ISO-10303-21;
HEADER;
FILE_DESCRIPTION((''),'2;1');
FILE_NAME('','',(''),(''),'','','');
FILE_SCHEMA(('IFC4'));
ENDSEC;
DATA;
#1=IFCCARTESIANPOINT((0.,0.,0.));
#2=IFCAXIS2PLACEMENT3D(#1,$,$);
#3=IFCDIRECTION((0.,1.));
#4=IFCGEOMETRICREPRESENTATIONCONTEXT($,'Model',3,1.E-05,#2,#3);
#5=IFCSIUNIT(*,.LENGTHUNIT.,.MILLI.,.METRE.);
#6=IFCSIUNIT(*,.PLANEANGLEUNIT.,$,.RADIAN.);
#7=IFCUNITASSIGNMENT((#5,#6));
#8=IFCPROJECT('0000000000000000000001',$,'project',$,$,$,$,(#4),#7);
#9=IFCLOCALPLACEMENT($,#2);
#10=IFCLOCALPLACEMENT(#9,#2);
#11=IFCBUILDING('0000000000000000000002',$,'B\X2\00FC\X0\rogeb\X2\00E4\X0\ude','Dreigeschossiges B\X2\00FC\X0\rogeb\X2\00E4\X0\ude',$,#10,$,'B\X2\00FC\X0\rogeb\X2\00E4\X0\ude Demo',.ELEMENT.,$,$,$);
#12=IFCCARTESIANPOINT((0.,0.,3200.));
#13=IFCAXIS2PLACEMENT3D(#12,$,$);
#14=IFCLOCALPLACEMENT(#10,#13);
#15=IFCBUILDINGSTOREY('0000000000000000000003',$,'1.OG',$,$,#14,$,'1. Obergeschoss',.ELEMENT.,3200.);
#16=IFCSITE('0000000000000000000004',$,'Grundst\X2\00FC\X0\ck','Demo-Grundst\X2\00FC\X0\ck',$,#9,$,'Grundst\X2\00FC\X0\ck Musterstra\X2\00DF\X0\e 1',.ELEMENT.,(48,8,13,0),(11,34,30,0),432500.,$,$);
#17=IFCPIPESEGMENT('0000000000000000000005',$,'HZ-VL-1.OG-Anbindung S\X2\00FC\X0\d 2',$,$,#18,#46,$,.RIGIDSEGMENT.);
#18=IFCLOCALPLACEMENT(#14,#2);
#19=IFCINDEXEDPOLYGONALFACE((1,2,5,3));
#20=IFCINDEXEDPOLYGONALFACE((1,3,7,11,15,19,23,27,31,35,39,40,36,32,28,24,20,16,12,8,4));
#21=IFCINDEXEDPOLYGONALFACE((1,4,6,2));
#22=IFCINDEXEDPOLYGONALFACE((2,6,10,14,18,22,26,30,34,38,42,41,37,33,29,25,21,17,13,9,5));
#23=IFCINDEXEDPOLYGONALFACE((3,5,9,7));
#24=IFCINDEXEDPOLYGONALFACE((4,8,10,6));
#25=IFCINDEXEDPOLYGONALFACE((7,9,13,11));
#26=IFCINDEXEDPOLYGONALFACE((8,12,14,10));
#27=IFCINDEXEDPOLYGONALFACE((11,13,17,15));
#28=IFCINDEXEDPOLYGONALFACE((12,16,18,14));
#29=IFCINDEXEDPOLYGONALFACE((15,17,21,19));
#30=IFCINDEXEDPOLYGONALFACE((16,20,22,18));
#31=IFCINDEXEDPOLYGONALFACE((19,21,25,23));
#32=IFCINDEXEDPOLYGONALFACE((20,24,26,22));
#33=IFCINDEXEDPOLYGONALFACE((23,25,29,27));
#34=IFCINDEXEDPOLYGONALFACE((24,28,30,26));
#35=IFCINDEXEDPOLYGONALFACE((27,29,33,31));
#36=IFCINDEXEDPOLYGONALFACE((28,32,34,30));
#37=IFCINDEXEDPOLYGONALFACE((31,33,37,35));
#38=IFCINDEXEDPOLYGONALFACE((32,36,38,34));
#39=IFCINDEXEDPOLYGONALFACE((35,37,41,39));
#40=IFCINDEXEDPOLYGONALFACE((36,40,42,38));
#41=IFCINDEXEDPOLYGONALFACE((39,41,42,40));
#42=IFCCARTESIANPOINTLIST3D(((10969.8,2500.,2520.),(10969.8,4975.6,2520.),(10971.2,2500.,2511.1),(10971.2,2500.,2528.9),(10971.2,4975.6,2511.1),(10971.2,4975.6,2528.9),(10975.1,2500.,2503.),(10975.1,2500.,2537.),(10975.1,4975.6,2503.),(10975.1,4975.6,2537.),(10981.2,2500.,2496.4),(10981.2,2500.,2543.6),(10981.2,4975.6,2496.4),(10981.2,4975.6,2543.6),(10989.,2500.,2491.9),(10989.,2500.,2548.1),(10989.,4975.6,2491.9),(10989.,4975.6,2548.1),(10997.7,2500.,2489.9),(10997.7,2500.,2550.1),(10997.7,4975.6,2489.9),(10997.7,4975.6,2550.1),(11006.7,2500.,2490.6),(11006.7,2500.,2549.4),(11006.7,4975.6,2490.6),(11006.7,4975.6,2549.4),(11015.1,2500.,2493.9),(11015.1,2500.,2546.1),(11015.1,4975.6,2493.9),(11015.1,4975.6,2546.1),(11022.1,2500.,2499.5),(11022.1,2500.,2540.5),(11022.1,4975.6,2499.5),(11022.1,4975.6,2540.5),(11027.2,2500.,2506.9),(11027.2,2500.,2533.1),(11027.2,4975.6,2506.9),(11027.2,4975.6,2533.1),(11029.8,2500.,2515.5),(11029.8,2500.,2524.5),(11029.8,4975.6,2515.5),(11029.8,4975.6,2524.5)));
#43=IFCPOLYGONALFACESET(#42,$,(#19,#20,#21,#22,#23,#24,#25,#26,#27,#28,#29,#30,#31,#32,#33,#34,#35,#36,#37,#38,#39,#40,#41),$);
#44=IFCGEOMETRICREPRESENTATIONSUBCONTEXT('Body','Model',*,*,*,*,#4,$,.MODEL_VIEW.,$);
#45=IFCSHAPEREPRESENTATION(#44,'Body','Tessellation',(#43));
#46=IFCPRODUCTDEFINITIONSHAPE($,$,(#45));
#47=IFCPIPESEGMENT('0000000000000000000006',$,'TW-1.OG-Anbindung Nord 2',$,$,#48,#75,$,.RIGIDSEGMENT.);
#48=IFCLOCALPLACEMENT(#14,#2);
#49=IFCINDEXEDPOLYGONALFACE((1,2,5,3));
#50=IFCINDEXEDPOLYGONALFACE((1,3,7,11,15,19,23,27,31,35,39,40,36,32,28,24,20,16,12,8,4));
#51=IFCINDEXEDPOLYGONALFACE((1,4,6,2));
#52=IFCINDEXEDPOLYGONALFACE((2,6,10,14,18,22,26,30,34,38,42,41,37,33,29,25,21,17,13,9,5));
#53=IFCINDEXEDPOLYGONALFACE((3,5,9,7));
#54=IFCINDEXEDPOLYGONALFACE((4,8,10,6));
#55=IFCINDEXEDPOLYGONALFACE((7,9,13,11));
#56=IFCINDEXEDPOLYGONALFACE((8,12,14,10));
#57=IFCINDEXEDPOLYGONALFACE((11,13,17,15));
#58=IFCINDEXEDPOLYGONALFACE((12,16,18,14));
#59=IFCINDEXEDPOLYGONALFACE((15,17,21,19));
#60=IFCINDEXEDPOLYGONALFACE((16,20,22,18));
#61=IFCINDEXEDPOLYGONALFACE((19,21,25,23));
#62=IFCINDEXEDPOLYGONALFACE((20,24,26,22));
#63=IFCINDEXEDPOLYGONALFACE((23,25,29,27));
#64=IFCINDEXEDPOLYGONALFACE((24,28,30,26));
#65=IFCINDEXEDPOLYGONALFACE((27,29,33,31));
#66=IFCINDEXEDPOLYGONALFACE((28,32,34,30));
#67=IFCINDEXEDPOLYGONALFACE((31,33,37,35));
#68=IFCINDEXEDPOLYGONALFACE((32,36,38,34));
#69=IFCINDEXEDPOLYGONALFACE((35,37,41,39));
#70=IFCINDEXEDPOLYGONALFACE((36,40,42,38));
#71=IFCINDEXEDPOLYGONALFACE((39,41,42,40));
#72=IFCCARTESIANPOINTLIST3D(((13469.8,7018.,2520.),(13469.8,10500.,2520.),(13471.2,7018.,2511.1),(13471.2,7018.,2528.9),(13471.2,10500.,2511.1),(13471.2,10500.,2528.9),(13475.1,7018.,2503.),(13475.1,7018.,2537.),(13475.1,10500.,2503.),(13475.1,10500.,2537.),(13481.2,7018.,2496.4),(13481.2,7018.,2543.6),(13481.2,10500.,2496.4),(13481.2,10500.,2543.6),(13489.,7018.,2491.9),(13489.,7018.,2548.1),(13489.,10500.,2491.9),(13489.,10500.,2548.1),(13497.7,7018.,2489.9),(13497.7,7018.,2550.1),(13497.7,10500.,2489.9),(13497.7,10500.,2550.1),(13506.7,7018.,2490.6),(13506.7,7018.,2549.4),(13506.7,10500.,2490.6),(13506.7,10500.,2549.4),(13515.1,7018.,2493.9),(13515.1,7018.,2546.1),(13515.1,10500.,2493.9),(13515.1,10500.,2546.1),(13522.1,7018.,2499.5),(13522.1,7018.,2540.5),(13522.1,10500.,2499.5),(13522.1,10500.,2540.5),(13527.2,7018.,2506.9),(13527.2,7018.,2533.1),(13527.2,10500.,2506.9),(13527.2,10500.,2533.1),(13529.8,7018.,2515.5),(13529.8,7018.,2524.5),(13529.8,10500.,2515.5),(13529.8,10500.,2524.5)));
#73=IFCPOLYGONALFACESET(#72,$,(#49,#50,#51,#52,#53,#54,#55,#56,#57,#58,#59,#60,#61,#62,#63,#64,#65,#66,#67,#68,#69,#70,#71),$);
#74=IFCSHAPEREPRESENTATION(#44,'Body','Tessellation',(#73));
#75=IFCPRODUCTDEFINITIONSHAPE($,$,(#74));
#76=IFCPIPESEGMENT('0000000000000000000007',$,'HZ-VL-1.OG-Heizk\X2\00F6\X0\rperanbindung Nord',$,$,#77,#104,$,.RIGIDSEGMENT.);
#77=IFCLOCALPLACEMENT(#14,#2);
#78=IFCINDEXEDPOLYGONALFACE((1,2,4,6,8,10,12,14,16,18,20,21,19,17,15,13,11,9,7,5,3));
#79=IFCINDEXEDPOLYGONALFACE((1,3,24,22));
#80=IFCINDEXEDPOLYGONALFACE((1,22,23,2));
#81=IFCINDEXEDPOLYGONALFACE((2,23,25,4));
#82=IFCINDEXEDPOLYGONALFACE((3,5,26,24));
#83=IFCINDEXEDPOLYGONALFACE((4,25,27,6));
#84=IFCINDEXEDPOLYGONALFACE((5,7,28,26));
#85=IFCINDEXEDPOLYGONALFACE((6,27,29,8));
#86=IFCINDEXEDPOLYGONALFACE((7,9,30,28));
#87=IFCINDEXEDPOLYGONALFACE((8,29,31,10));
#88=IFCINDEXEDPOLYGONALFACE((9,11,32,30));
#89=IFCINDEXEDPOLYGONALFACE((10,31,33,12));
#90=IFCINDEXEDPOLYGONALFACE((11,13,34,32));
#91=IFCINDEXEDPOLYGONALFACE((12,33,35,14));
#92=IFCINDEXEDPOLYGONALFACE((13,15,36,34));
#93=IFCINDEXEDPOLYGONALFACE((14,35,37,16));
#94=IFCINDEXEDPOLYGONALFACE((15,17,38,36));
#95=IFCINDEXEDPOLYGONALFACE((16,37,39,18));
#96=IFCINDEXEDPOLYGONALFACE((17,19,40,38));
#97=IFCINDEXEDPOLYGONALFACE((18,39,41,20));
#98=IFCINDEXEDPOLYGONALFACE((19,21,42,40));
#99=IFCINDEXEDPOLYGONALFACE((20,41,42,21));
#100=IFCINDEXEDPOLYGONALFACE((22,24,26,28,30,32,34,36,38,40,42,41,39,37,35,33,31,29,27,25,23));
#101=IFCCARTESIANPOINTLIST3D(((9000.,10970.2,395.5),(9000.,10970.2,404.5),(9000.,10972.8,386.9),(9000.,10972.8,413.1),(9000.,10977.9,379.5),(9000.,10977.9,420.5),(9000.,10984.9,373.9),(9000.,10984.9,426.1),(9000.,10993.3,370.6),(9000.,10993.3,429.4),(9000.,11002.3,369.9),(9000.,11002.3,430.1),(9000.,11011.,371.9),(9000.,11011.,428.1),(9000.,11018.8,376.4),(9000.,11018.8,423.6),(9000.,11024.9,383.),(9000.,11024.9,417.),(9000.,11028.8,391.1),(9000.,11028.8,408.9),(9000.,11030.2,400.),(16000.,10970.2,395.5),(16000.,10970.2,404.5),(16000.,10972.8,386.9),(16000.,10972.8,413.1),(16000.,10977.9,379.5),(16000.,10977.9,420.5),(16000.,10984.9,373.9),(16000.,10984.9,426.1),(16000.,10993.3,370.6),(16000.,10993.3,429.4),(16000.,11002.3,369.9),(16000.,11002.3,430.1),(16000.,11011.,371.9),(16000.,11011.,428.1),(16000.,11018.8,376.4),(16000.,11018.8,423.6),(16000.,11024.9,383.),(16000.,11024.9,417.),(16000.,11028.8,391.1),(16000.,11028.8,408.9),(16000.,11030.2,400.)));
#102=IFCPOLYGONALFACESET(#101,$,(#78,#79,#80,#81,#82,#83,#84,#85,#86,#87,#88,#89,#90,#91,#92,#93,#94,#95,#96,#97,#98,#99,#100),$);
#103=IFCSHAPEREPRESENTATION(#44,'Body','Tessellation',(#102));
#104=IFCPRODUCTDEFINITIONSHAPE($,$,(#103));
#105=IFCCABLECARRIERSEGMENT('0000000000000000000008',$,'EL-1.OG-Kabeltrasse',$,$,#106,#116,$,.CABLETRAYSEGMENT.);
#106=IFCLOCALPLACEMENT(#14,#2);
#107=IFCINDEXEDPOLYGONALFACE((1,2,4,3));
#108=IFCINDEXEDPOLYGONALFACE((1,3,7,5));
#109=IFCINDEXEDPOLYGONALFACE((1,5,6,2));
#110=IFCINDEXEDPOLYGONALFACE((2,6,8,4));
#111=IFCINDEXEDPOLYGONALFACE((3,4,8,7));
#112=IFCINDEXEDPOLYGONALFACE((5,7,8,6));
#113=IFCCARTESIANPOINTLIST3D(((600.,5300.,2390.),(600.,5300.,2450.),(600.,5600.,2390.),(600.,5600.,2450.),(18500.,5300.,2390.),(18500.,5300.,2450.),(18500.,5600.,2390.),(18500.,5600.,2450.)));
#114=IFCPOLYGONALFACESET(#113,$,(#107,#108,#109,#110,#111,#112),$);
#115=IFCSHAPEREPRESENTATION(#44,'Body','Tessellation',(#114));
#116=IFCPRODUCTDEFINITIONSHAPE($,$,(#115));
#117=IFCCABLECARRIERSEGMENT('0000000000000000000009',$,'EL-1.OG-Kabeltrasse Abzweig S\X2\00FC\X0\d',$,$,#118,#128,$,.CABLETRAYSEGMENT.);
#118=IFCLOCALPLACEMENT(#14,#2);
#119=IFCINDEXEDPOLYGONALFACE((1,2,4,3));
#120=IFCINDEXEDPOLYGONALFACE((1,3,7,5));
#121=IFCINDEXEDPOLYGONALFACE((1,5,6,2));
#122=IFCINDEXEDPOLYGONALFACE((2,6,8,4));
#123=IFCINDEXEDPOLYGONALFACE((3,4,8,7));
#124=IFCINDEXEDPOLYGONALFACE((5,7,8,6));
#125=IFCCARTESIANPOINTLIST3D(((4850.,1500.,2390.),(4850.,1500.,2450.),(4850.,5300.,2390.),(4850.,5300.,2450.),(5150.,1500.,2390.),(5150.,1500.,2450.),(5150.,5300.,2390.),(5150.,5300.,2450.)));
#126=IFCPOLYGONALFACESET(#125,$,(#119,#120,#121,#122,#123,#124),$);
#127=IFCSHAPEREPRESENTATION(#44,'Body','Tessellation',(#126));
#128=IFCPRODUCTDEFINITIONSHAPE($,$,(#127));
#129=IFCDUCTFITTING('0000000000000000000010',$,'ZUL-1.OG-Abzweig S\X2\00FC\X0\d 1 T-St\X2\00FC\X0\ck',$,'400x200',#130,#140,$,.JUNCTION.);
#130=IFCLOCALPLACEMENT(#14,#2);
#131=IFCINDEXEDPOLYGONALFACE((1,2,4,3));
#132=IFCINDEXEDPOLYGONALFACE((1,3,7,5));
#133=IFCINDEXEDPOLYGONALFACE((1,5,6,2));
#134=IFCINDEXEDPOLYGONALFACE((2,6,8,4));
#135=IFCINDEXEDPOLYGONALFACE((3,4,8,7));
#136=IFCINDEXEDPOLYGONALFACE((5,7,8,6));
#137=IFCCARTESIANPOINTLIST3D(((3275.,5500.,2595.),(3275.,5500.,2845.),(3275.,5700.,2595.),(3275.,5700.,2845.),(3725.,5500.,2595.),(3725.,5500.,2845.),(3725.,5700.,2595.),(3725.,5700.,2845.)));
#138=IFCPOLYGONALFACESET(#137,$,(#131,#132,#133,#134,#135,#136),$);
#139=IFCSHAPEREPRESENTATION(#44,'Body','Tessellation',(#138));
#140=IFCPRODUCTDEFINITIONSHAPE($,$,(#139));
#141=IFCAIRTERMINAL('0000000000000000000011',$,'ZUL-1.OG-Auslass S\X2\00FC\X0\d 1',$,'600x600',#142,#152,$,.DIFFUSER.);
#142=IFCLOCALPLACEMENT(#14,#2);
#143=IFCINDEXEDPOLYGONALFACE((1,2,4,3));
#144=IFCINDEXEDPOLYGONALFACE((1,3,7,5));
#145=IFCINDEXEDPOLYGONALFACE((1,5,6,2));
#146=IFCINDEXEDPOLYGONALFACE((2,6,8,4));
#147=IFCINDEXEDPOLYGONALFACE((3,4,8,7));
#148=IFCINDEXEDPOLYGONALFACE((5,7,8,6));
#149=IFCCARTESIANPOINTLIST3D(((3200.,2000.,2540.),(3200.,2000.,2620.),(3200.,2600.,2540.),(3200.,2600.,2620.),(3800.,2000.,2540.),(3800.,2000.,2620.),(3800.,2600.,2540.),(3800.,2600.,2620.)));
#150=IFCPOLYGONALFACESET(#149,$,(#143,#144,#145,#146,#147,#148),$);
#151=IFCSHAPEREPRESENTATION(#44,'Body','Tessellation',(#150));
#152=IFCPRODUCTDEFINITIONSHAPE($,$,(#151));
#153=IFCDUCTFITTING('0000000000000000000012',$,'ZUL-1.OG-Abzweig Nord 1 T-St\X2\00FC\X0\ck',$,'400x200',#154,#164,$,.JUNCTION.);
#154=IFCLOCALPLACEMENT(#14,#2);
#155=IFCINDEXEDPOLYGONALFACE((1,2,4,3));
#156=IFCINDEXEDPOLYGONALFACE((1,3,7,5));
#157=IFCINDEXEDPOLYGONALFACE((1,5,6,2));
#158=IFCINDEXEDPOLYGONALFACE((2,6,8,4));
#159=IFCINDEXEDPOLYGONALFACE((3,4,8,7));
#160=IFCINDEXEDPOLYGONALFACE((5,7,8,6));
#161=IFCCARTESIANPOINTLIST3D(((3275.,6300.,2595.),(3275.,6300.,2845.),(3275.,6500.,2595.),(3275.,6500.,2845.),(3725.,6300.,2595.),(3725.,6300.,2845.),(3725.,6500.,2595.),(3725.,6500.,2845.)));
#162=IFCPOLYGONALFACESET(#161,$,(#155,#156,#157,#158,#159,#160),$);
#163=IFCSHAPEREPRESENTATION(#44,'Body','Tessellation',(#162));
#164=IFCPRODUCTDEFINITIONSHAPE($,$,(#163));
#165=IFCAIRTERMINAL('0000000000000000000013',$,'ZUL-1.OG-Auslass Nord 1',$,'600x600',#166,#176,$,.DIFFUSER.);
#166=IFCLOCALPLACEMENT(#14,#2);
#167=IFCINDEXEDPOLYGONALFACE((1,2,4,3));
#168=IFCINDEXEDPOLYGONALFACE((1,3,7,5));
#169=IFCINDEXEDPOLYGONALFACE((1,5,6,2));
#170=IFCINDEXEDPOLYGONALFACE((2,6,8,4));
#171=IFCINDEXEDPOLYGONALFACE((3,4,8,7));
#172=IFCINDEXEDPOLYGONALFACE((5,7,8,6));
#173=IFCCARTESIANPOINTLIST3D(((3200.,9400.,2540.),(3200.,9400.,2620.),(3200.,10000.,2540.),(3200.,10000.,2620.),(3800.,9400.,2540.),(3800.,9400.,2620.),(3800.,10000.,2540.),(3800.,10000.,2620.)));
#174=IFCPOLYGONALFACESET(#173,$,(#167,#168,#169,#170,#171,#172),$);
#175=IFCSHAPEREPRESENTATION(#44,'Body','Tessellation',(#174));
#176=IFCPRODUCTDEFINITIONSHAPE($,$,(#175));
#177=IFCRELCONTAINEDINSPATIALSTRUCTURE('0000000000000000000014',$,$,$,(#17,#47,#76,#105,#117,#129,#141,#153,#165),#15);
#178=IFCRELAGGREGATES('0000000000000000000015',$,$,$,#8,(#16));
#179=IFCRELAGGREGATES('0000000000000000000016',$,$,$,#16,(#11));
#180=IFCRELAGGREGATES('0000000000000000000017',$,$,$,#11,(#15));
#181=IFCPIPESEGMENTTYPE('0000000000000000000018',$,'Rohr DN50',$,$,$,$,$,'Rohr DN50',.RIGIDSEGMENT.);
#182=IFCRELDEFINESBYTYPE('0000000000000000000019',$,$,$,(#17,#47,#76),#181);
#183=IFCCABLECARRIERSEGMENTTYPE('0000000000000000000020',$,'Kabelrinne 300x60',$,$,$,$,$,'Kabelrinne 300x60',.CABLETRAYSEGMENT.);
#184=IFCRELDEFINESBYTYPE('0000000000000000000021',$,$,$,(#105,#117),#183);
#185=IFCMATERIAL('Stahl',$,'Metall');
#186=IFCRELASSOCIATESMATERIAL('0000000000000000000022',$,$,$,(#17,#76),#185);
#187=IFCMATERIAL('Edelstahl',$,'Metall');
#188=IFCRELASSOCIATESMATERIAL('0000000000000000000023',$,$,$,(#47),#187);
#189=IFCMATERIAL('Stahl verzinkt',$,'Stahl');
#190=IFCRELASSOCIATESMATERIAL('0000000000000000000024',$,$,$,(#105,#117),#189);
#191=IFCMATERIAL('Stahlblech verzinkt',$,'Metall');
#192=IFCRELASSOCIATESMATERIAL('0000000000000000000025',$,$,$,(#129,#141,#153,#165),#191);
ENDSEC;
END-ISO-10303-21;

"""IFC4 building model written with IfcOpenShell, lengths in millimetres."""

from ifc_helpers import new_model, si_unit, direction, frame, origin, origin_2d, place, context, subcontext, project, spatial, rectangle, circle, extrude, material, type_object, element, save


model = new_model("IFC4")

# Units and contexts
model_context = context("Model", 3, precision=1e-05, world=origin(), true_north=direction((0.0, 1.0)))
body_context = subcontext(model_context, "Body", "Model", "MODEL_VIEW")
ifc_project = project(units=[si_unit("LENGTHUNIT", "METRE", prefix="MILLI"), si_unit("PLANEANGLEUNIT", "RADIAN")], contexts=[model_context])

# Site, building, storey
site_placement = place(None, origin())
site = spatial("IfcSite", under=ifc_project, at=site_placement, Name="Grundstück", Description="Demo-Grundstück", LongName="Grundstück Musterstraße 1", CompositionType="ELEMENT", RefLatitude=(48, 8, 13, 0), RefLongitude=(11, 34, 30, 0), RefElevation=432500.0)
building_placement = place(site_placement, origin())
building = spatial("IfcBuilding", under=site, at=building_placement, Name="Bürogebäude", Description="Dreigeschossiges Bürogebäude", LongName="Bürogebäude Demo", CompositionType="ELEMENT")
storey_placement = place(building_placement, frame((0.0, 0.0, 3200.0)))
storey = spatial("IfcBuildingStorey", under=building, at=storey_placement, Name="1.OG", LongName="1. Obergeschoss", CompositionType="ELEMENT", Elevation=3200.0)

# Shared definitions
ifc_material_1 = material(Name="Stahlblech verzinkt", Category="Metall")

# Pipe segments
ifc_material_2 = material(Name="Stahl", Category="Metall")
ifc_material_3 = material(Name="Edelstahl", Category="Metall")
pipe_segment_type_1 = type_object("IfcPipeSegmentType", Name="Rohr DN50", ElementType="Rohr DN50", PredefinedType="RIGIDSEGMENT")
pipe_segment_1_placement = place(storey_placement, frame((11000.0, 2500.0, 2520.0)))
element("IfcPipeSegment", 1, at=pipe_segment_1_placement, inside=storey, type_object=pipe_segment_type_1, material=ifc_material_2, Name="HZ-VL-1.OG-Anbindung Süd 2", PredefinedType="RIGIDSEGMENT", context=body_context, shape_type="SweptSolid", body=[
    extrude(circle(Radius=30.1, at=origin_2d()), frame((0.0, 0.0, 0.0), z_axis=(0.0, 1.0, 0.0), x_axis=(-1.0, 0.0, 0.0)), (0.0, 0.0, 1.0), 2475.6),
])
pipe_segment_2_placement = place(storey_placement, frame((13500.0, 7018.1, 2520.0)))
element("IfcPipeSegment", 2, at=pipe_segment_2_placement, inside=storey, type_object=pipe_segment_type_1, material=ifc_material_3, Name="TW-1.OG-Anbindung Nord 2", PredefinedType="RIGIDSEGMENT", context=body_context, shape_type="SweptSolid", body=[
    extrude(circle(Radius=30.1, at=origin_2d()), frame((0.0, 0.0, 0.0), z_axis=(0.0, 1.0, 0.0), x_axis=(-1.0, 0.0, 0.0)), (0.0, 0.0, 1.0), 3481.9),
])
pipe_segment_3_placement = place(storey_placement, frame((9000.0, 11000.0, 400.0)))
element("IfcPipeSegment", 3, at=pipe_segment_3_placement, inside=storey, type_object=pipe_segment_type_1, material=ifc_material_2, Name="HZ-VL-1.OG-Heizkörperanbindung Nord", PredefinedType="RIGIDSEGMENT", context=body_context, shape_type="SweptSolid", body=[
    extrude(circle(Radius=30.1, at=origin_2d()), frame((0.0, 0.0, 0.0), z_axis=(1.0, 0.0, 0.0), x_axis=(0.0, 1.0, 0.0)), (0.0, 0.0, 1.0), 7000.0),
])

# Cable carrier segments
ifc_material_4 = material(Name="Stahl verzinkt", Category="Stahl")
cable_carrier_segment_type = type_object("IfcCableCarrierSegmentType", Name="Kabelrinne 300x60", ElementType="Kabelrinne 300x60", PredefinedType="CABLETRAYSEGMENT")
cable_carrier_segment_1_placement = place(storey_placement, frame((600.0, 5450.0, 2420.0)))
element("IfcCableCarrierSegment", 4, at=cable_carrier_segment_1_placement, inside=storey, type_object=cable_carrier_segment_type, material=ifc_material_4, Name="EL-1.OG-Kabeltrasse", PredefinedType="CABLETRAYSEGMENT", context=body_context, shape_type="SweptSolid", body=[
    extrude(rectangle(XDim=300.0, YDim=60.0, at=origin_2d()), frame((0.0, 0.0, 0.0), z_axis=(1.0, 0.0, 0.0), x_axis=(0.0, 1.0, 0.0)), (0.0, 0.0, 1.0), 17900.0),
])
cable_carrier_segment_2_placement = place(storey_placement, frame((5000.0, 1500.0, 2420.0)))
element("IfcCableCarrierSegment", 5, at=cable_carrier_segment_2_placement, inside=storey, type_object=cable_carrier_segment_type, material=ifc_material_4, Name="EL-1.OG-Kabeltrasse Abzweig Süd", PredefinedType="CABLETRAYSEGMENT", context=body_context, shape_type="SweptSolid", body=[
    extrude(rectangle(XDim=300.0, YDim=60.0, at=origin_2d()), frame((0.0, 0.0, 0.0), z_axis=(0.0, 1.0, 0.0), x_axis=(-1.0, 0.0, 0.0)), (0.0, 0.0, 1.0), 3800.0),
])

# Duct fitting
duct_fitting_1_placement = place(storey_placement, frame((3500.0, 5500.0, 2720.0)))
element("IfcDuctFitting", 6, at=duct_fitting_1_placement, inside=storey, material=ifc_material_1, Name="ZUL-1.OG-Abzweig Süd 1 T-Stück", ObjectType="400x200", PredefinedType="JUNCTION", context=body_context, shape_type="SweptSolid", body=[
    extrude(rectangle(XDim=450.0, YDim=250.0, at=origin_2d()), frame((0.0, 0.0, 0.0), z_axis=(0.0, 1.0, 0.0), x_axis=(-1.0, 0.0, 0.0)), (0.0, 0.0, 1.0), 200.0),
])

# Air terminal
air_terminal_1_placement = place(storey_placement, frame((3500.0, 2300.0, 2540.0)))
element("IfcAirTerminal", 7, at=air_terminal_1_placement, inside=storey, material=ifc_material_1, Name="ZUL-1.OG-Auslass Süd 1", ObjectType="600x600", PredefinedType="DIFFUSER", context=body_context, shape_type="SweptSolid", body=[
    extrude(rectangle(XDim=600.0, YDim=600.0, at=origin_2d()), origin(), (0.0, 0.0, 1.0), 80.0),
])

# Duct fitting
duct_fitting_2_placement = place(storey_placement, frame((3500.0, 6300.0, 2720.0)))
element("IfcDuctFitting", 8, at=duct_fitting_2_placement, inside=storey, material=ifc_material_1, Name="ZUL-1.OG-Abzweig Nord 1 T-Stück", ObjectType="400x200", PredefinedType="JUNCTION", context=body_context, shape_type="SweptSolid", body=[
    extrude(rectangle(XDim=450.0, YDim=250.0, at=origin_2d()), frame((0.0, 0.0, 0.0), z_axis=(0.0, 1.0, 0.0), x_axis=(-1.0, 0.0, 0.0)), (0.0, 0.0, 1.0), 200.0),
])

# Air terminal
air_terminal_2_placement = place(storey_placement, frame((3500.0, 9700.0, 2540.0)))
element("IfcAirTerminal", 9, at=air_terminal_2_placement, inside=storey, material=ifc_material_1, Name="ZUL-1.OG-Auslass Nord 1", ObjectType="600x600", PredefinedType="DIFFUSER", context=body_context, shape_type="SweptSolid", body=[
    extrude(rectangle(XDim=600.0, YDim=600.0, at=origin_2d()), origin(), (0.0, 0.0, 1.0), 80.0),
])

save(model, "model.ifc")
